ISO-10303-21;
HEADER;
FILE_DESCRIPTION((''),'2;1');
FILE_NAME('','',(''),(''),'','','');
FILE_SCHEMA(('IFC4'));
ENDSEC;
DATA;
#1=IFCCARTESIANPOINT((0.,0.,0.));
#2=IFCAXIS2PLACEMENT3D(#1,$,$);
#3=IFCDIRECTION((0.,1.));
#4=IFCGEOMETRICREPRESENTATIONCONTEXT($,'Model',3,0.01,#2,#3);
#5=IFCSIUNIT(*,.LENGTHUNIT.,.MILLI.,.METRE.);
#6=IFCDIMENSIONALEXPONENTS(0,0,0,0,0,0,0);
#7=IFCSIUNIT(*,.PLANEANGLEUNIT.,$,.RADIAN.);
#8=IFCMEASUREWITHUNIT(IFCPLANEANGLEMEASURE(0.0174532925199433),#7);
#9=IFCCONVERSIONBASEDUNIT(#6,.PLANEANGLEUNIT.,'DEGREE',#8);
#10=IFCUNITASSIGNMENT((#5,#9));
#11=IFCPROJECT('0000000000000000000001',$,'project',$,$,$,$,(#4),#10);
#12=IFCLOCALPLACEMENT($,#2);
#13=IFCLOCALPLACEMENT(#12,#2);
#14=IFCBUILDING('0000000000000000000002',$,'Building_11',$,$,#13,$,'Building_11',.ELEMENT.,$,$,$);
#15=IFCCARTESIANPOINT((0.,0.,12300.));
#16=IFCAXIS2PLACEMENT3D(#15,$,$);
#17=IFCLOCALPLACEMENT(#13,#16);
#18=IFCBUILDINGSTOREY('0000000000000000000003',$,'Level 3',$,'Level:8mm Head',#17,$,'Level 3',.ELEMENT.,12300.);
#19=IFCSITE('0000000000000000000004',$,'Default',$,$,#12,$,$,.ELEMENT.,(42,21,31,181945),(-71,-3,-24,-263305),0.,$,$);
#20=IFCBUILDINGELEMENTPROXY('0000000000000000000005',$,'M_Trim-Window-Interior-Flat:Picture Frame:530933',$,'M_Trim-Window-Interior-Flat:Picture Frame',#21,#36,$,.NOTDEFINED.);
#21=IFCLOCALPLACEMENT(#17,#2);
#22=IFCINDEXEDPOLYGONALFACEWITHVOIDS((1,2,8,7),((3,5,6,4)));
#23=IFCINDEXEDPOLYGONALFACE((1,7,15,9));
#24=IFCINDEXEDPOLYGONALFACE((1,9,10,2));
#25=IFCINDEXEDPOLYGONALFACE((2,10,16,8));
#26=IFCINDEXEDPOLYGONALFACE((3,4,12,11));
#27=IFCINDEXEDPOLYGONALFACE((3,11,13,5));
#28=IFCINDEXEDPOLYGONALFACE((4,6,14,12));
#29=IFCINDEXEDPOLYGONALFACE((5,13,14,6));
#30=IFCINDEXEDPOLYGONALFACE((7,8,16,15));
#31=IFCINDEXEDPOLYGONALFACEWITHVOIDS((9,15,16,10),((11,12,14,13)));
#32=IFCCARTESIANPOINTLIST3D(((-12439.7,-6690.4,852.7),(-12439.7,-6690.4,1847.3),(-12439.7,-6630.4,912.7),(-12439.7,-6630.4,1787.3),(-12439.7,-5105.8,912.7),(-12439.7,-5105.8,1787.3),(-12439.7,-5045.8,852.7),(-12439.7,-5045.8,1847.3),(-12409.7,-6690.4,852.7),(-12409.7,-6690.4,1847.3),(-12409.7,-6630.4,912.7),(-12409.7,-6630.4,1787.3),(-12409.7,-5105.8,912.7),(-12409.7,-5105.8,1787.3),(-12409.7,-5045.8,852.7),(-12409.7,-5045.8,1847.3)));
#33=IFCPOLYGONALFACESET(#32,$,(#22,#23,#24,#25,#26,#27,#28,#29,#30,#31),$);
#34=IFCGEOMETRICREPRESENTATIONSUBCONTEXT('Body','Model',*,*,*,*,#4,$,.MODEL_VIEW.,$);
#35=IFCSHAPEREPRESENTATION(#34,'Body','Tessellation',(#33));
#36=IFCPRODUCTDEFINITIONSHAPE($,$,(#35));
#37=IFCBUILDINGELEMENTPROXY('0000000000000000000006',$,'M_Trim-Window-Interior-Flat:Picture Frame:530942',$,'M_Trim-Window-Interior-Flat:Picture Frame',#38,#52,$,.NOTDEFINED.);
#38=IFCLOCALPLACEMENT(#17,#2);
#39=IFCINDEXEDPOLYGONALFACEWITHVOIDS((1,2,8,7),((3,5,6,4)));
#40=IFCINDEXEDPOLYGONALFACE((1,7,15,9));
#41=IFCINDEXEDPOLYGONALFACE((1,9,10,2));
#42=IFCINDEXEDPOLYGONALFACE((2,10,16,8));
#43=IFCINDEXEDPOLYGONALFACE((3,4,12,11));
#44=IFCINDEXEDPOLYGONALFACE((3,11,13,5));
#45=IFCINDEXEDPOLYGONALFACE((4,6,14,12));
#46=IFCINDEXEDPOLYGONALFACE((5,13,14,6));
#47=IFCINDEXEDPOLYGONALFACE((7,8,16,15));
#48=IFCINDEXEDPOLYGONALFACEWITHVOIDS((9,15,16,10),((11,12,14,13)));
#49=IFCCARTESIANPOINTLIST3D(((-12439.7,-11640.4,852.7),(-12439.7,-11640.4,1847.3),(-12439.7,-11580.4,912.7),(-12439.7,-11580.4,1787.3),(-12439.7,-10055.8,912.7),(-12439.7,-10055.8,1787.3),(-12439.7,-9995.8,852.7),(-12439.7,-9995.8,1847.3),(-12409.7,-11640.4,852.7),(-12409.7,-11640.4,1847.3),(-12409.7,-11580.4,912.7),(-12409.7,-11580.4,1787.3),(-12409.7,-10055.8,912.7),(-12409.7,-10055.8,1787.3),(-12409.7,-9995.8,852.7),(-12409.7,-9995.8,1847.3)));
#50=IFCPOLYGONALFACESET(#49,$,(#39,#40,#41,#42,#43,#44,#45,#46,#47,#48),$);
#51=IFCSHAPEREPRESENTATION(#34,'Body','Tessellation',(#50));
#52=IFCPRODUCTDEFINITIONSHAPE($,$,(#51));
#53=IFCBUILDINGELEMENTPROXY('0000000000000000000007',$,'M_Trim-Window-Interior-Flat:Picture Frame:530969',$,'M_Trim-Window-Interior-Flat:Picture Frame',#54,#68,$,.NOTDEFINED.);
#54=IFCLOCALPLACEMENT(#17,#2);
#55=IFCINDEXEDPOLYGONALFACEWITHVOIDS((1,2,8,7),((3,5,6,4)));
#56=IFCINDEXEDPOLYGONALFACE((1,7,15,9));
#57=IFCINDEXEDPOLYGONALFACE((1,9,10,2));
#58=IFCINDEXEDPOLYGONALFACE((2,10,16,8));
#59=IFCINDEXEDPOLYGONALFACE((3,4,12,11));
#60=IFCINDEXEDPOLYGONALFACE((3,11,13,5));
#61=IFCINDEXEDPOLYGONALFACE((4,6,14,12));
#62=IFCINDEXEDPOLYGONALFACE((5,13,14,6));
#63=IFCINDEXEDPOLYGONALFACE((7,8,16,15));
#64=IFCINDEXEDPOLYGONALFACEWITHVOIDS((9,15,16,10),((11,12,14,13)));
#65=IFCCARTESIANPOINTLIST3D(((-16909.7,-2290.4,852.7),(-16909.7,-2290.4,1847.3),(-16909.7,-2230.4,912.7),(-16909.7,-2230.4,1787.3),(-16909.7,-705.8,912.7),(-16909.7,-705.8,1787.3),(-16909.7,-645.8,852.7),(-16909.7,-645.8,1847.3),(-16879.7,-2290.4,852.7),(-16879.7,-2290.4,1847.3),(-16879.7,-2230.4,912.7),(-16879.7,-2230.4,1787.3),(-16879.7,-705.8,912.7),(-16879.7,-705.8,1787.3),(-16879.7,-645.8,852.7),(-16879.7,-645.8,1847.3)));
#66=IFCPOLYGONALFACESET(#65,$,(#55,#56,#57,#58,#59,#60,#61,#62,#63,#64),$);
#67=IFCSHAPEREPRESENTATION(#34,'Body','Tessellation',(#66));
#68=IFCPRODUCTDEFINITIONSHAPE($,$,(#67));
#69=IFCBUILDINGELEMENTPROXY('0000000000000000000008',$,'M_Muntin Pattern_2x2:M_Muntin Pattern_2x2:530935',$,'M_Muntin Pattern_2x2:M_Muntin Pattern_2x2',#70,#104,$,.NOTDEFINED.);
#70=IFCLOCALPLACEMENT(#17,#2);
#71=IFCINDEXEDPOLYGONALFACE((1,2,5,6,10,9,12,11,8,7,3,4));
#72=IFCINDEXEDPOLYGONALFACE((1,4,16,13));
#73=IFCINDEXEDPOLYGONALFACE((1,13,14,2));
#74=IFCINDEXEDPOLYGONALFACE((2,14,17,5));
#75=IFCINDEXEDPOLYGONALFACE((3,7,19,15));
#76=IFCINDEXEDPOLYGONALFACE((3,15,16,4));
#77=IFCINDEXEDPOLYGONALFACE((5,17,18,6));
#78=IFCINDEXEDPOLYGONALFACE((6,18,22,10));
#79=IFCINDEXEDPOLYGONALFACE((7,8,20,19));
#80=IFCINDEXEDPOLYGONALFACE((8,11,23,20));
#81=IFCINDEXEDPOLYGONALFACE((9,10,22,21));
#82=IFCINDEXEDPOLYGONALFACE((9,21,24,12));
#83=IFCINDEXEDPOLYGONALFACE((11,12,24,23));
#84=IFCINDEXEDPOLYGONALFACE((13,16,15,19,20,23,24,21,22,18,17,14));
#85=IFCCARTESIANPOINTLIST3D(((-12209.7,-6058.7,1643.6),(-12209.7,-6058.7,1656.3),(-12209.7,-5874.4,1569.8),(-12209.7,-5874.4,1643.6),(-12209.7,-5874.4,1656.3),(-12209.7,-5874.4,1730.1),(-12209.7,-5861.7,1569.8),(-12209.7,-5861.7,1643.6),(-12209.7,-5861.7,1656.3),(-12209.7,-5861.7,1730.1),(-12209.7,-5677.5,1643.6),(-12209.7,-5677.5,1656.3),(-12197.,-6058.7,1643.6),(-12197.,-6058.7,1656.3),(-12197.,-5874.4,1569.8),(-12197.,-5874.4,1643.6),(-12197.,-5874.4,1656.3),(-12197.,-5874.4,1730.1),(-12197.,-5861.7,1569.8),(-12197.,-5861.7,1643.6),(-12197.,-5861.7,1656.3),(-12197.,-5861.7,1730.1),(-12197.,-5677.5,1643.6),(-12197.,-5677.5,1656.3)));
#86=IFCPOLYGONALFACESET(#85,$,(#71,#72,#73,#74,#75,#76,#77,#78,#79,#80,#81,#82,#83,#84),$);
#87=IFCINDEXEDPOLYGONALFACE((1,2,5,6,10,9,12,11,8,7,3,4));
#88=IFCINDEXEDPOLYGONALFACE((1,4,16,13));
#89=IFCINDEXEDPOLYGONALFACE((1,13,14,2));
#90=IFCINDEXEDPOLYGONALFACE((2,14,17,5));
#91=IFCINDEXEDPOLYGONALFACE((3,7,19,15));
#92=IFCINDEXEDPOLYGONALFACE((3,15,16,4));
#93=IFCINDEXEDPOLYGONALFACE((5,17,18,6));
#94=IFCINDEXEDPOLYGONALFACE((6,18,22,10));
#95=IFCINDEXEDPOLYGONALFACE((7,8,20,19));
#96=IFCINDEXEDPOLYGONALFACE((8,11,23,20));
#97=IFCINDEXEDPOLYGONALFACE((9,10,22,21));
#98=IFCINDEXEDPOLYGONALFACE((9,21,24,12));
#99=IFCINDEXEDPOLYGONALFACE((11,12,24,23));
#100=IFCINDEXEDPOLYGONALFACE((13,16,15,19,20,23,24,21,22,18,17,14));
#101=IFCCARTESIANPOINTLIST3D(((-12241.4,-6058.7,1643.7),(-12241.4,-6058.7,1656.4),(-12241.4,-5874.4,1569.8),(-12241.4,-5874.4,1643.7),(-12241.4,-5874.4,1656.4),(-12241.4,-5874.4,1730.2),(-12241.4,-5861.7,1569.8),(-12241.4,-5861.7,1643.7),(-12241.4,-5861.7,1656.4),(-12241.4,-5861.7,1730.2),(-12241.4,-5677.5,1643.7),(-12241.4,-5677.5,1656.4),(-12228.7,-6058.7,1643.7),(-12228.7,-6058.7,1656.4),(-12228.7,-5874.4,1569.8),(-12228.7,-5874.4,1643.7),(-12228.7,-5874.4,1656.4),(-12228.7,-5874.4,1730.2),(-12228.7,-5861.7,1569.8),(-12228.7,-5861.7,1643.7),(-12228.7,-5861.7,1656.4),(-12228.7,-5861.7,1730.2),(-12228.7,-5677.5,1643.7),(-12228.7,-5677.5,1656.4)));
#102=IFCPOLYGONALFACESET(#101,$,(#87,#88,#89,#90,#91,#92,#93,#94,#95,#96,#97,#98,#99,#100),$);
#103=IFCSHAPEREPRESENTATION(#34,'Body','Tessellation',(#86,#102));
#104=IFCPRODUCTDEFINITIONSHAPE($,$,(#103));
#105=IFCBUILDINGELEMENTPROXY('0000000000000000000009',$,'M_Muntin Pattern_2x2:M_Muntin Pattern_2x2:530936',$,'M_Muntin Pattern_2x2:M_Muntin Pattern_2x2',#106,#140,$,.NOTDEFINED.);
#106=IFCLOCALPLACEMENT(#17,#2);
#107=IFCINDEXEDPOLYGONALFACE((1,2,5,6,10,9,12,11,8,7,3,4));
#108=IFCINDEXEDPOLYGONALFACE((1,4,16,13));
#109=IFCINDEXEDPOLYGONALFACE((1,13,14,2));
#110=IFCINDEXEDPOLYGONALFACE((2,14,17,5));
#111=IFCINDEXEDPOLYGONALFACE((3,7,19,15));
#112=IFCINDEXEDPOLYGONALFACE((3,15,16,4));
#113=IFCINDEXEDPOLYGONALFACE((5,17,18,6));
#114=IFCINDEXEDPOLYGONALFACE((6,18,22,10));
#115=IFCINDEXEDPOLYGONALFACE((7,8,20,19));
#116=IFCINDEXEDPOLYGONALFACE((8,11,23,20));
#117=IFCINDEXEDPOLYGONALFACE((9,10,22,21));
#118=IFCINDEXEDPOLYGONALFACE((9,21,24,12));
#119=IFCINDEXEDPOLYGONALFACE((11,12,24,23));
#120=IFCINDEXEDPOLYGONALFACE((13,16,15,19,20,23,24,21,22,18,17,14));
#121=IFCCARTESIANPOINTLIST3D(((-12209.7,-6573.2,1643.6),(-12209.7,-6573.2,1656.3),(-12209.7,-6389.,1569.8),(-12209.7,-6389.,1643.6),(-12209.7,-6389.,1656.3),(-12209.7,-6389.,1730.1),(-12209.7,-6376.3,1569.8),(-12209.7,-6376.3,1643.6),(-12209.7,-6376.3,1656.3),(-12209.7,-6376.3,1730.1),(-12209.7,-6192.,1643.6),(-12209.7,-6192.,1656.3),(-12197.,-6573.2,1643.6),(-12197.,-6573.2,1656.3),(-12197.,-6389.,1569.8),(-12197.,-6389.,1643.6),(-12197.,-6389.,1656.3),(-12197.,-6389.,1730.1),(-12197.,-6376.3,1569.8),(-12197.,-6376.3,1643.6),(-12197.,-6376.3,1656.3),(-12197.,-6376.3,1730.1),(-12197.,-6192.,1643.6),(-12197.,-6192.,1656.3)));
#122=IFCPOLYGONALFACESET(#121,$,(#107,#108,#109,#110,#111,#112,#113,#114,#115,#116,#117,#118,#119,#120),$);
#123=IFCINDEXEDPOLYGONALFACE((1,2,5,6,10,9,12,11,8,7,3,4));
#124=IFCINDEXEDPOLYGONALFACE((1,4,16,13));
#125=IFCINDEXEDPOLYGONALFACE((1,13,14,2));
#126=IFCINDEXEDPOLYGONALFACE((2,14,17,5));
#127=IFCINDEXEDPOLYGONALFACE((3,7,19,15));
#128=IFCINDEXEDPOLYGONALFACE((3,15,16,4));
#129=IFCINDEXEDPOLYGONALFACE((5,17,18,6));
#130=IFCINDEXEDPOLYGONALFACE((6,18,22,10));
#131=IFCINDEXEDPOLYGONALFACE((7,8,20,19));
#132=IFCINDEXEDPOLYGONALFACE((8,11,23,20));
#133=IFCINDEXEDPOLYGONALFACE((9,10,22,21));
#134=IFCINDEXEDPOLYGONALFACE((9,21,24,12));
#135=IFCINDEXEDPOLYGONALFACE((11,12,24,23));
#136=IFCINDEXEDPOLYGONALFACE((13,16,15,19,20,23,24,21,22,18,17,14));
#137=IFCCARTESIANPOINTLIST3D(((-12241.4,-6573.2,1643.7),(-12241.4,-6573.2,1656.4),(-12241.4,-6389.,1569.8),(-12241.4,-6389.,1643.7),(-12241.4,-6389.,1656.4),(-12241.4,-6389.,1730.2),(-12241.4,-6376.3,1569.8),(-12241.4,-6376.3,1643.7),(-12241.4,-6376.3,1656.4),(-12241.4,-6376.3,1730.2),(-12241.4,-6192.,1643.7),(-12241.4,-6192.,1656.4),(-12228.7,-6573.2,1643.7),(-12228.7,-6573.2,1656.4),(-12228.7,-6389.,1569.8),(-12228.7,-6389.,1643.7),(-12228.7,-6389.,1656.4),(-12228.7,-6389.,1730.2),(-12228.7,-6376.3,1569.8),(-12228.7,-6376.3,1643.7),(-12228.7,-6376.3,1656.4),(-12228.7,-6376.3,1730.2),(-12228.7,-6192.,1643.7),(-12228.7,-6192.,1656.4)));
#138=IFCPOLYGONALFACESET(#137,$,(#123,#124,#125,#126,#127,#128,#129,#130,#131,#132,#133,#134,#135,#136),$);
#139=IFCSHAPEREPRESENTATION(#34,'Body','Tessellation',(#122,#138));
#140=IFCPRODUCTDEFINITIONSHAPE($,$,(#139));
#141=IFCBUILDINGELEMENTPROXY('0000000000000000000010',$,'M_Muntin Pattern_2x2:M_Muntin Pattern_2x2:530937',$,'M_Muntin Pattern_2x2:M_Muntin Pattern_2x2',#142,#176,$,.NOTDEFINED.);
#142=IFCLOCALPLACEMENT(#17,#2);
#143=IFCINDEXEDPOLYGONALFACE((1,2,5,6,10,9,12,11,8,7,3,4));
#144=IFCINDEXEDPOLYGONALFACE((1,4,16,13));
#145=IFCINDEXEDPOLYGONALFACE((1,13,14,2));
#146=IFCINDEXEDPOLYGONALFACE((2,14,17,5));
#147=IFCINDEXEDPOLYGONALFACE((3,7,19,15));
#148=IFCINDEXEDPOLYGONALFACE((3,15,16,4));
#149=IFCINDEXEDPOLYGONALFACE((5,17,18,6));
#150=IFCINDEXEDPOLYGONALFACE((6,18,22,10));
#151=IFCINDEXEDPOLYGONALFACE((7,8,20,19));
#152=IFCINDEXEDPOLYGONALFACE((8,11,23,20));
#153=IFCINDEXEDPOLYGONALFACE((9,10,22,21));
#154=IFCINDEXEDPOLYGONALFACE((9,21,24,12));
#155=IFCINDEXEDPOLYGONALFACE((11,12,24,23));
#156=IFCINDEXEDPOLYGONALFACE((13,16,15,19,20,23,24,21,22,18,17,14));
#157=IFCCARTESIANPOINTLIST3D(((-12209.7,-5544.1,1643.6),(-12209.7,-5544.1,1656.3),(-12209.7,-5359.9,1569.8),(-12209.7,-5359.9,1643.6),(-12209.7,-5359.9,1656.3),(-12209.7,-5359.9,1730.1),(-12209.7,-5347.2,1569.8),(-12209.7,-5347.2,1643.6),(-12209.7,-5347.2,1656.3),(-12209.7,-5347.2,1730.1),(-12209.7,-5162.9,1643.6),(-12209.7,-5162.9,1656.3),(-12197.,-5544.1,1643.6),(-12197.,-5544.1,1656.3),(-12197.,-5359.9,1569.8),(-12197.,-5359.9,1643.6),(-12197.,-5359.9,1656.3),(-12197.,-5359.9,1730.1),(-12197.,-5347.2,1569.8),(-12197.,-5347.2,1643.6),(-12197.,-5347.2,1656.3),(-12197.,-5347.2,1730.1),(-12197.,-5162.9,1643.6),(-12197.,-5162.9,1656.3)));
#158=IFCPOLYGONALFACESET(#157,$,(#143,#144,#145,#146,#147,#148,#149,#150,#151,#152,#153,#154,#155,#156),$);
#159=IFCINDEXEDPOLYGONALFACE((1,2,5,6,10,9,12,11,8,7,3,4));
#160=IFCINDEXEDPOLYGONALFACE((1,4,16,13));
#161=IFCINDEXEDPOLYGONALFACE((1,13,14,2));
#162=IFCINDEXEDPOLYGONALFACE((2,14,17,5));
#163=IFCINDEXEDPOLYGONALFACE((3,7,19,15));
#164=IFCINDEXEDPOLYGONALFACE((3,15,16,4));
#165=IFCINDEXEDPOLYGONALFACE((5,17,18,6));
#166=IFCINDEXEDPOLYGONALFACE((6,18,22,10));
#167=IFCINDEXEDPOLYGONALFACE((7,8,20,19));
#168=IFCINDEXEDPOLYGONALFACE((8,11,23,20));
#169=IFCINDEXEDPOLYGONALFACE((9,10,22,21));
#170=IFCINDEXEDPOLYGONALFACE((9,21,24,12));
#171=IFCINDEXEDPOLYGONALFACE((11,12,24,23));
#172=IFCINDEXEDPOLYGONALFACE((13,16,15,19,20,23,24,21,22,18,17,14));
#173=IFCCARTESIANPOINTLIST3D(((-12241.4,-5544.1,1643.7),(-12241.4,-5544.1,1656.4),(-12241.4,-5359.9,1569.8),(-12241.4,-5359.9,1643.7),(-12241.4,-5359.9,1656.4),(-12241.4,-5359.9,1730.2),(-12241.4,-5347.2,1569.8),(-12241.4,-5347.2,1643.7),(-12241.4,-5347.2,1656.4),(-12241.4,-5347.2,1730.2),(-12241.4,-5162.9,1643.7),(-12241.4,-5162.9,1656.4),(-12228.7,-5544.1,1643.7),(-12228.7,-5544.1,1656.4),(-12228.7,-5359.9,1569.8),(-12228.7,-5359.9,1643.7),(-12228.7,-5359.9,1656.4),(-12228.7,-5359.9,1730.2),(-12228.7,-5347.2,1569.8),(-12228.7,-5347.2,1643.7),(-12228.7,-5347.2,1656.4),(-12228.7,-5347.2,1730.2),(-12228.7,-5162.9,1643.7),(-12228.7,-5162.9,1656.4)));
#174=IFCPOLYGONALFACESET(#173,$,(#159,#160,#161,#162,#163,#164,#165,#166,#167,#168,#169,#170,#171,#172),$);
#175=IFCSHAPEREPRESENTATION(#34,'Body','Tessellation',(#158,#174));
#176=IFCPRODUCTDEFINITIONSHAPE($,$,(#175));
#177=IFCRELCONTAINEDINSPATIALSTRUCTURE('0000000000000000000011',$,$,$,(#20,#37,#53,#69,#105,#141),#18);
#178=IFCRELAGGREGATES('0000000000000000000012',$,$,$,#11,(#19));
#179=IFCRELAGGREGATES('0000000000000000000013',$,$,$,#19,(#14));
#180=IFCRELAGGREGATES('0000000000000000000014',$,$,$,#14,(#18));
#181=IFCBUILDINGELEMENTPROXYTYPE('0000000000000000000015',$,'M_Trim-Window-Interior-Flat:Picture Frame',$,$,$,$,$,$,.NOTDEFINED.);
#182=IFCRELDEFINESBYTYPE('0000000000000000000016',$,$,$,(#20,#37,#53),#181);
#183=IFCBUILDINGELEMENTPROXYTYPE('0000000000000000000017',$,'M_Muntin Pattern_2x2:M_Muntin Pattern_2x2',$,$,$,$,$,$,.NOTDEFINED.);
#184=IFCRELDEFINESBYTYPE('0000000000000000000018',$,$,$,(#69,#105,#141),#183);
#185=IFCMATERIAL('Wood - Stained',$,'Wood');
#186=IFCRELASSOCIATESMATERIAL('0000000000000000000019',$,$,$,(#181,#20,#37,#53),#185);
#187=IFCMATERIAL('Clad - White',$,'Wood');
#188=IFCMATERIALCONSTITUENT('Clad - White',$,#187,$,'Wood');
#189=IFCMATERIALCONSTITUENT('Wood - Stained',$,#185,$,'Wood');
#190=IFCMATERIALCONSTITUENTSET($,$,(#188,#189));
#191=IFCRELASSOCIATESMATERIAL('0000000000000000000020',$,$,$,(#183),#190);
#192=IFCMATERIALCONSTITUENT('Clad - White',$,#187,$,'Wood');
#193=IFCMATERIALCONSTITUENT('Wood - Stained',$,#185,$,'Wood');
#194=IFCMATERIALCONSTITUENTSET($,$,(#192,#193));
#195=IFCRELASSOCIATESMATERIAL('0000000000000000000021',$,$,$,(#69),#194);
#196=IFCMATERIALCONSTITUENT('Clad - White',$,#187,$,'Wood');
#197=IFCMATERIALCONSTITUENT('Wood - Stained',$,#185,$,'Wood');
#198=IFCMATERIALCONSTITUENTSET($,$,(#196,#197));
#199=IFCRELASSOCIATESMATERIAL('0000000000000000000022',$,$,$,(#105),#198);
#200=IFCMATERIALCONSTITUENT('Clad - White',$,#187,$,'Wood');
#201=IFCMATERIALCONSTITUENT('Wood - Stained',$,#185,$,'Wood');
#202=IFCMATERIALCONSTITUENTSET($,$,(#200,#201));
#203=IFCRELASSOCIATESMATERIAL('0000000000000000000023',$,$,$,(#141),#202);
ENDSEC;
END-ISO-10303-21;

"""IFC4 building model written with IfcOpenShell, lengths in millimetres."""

from ifc_helpers import new_model, entity, si_unit, converted_unit, direction, frame, origin, place, context, subcontext, project, spatial, indexed_curve, outline, extrude, source, transform, mapped, material, constituent, constituent_set, type_object, type_shapes, element, save


model = new_model("IFC4")

# Units and contexts
model_context = context("Model", 3, precision=0.01, world=origin(), true_north=direction((0.0, 1.0)))
body_context = subcontext(model_context, "Body", "Model", "MODEL_VIEW")
ifc_project = project(units=[si_unit("LENGTHUNIT", "METRE", prefix="MILLI"), converted_unit("PLANEANGLEUNIT", "DEGREE", entity("IfcPlaneAngleMeasure", 0.0174532925199433), si_unit("PLANEANGLEUNIT", "RADIAN"), dimensions=[0, 0, 0, 0, 0, 0, 0])], contexts=[model_context])

# Site, building, storey
site_placement = place(None, origin())
site = spatial("IfcSite", under=ifc_project, at=site_placement, Name="Default", CompositionType="ELEMENT", RefLatitude=(42, 21, 31, 181945), RefLongitude=(-71, -3, -24, -263305), RefElevation=0.0)
building_placement = place(site_placement, origin())
building = spatial("IfcBuilding", under=site, at=building_placement, Name="Building_11", LongName="Building_11", CompositionType="ELEMENT")
storey_placement = place(building_placement, frame((0.0, 0.0, 12300.0)))
storey = spatial("IfcBuildingStorey", under=building, at=storey_placement, Name="Level 3", ObjectType="Level:8mm Head", LongName="Level 3", CompositionType="ELEMENT", Elevation=12300.0)

# Building element proxies
ifc_material_1 = material(Name="Clad - White", Category="Wood")
ifc_material_2 = material(Name="Wood - Stained", Category="Wood")
building_element_proxy_type_1 = type_object("IfcBuildingElementProxyType", Name="M_Trim-Window-Interior-Flat:Picture Frame", PredefinedType="NOTDEFINED", material=ifc_material_2)
shared_shape_1 = source(origin(), body_context, "Body", "SweptSolid", [
    extrude(outline(indexed_curve([(-822.3, -497.3), (822.3, -497.3), (822.3, 497.3), (-822.3, 497.3), (-822.3, -497.3)], self_intersect=False), holes=[indexed_curve([(-762.3, -437.3), (-762.3, 437.3), (762.3, 437.3), (762.3, -437.3), (-762.3, -437.3)], self_intersect=False)]), frame((0.0, -450.0, 0.0), z_axis=(0.0, 0.0, 1.0), x_axis=(-1.0, 0.0, 0.0)), (0.0, 0.0, 1.0), 30.0),
])
type_shapes(building_element_proxy_type_1, [shared_shape_1])
for number, where, z_axis, x_axis, name in (
    (1, (-12409.7, -5868.1, 1800.0), (-1.0, 0.0, 0.0), (0.0, -1.0, 0.0), "M_Trim-Window-Interior-Flat:Picture Frame:530933"),
    (2, (-12409.7, -10818.1, 1800.0), (-1.0, 0.0, 0.0), (0.0, -1.0, 0.0), "M_Trim-Window-Interior-Flat:Picture Frame:530942"),
    (3, (-16909.7, -1468.1, 1800.0), (1.0, 0.0, 0.0), (0.0, 1.0, 0.0), "M_Trim-Window-Interior-Flat:Picture Frame:530969"),
):
    element("IfcBuildingElementProxy", number, at=place(storey_placement, frame(where, z_axis=z_axis, x_axis=x_axis)), inside=storey, type_object=building_element_proxy_type_1, material=ifc_material_2, Name=name, ObjectType="M_Trim-Window-Interior-Flat:Picture Frame", PredefinedType="NOTDEFINED", context=body_context, shape_type="MappedRepresentation", body=[
        mapped(shared_shape_1, transform((0.0, 0.0, 0.0), scale=1.0)),
    ])
ifc_constituent_1 = constituent(ifc_material_1, Name="Clad - White", Category="Wood")
ifc_constituent_2 = constituent(ifc_material_2, Name="Wood - Stained", Category="Wood")
ifc_constituent_set_1 = constituent_set(constituents=[ifc_constituent_1, ifc_constituent_2])
ifc_constituent_3 = constituent(ifc_material_1, Name="Clad - White", Category="Wood")
ifc_constituent_4 = constituent(ifc_material_2, Name="Wood - Stained", Category="Wood")
ifc_constituent_set_2 = constituent_set(constituents=[ifc_constituent_3, ifc_constituent_4])
building_element_proxy_type_2 = type_object("IfcBuildingElementProxyType", Name="M_Muntin Pattern_2x2:M_Muntin Pattern_2x2", PredefinedType="NOTDEFINED", material=ifc_constituent_set_2)
shared_shape_2 = source(origin(), body_context, "Body", "SweptSolid", [
    extrude(outline(indexed_curve([(6.4, -6.4), (80.1, -6.4), (80.1, 6.3), (6.4, 6.3), (6.4, 190.6), (-6.3, 190.6), (-6.3, 6.3), (-80.2, 6.3), (-80.2, -6.4), (-6.3, -6.4), (-6.3, -190.6), (6.4, -190.6), (6.4, -6.4)], self_intersect=False)), frame((0.0, 9.5, 80.1), z_axis=(0.0, 1.0, 0.0), x_axis=(0.0, 0.0, 1.0)), (0.0, 0.0, 1.0), 12.7),
    extrude(outline(indexed_curve([(6.4, -6.4), (80.2, -6.4), (80.2, 6.3), (6.4, 6.3), (6.4, 190.6), (-6.3, 190.6), (-6.3, 6.3), (-80.2, 6.3), (-80.2, -6.4), (-6.3, -6.4), (-6.3, -190.6), (6.4, -190.6), (6.4, -6.4)], self_intersect=False)), frame((0.0, -22.2, 80.2), z_axis=(0.0, 1.0, 0.0), x_axis=(0.0, 0.0, 1.0)), (0.0, 0.0, 1.0), 12.7),
])
type_shapes(building_element_proxy_type_2, [shared_shape_2])
proxy_1_placement = place(storey_placement, frame((-12219.2, -5868.1, 1569.8), z_axis=(0.0, 0.0, 1.0), x_axis=(0.0, -1.0, 0.0)))
element("IfcBuildingElementProxy", 4, at=proxy_1_placement, inside=storey, type_object=building_element_proxy_type_2, material=ifc_constituent_set_1, Name="M_Muntin Pattern_2x2:M_Muntin Pattern_2x2:530935", ObjectType="M_Muntin Pattern_2x2:M_Muntin Pattern_2x2", PredefinedType="NOTDEFINED", context=body_context, shape_type="MappedRepresentation", body=[
    mapped(shared_shape_2, transform((0.0, 0.0, 0.0), scale=1.0)),
])
ifc_constituent_5 = constituent(ifc_material_1, Name="Clad - White", Category="Wood")
ifc_constituent_6 = constituent(ifc_material_2, Name="Wood - Stained", Category="Wood")
ifc_constituent_set_3 = constituent_set(constituents=[ifc_constituent_5, ifc_constituent_6])
proxy_2_placement = place(storey_placement, frame((-12219.2, -6382.6, 1569.8), z_axis=(0.0, 0.0, 1.0), x_axis=(0.0, -1.0, 0.0)))
element("IfcBuildingElementProxy", 5, at=proxy_2_placement, inside=storey, type_object=building_element_proxy_type_2, material=ifc_constituent_set_3, Name="M_Muntin Pattern_2x2:M_Muntin Pattern_2x2:530936", ObjectType="M_Muntin Pattern_2x2:M_Muntin Pattern_2x2", PredefinedType="NOTDEFINED", context=body_context, shape_type="MappedRepresentation", body=[
    mapped(shared_shape_2, transform((0.0, 0.0, 0.0), scale=1.0)),
])
ifc_constituent_7 = constituent(ifc_material_1, Name="Clad - White", Category="Wood")
ifc_constituent_8 = constituent(ifc_material_2, Name="Wood - Stained", Category="Wood")
ifc_constituent_set_4 = constituent_set(constituents=[ifc_constituent_7, ifc_constituent_8])
proxy_3_placement = place(storey_placement, frame((-12219.2, -5353.5, 1569.8), z_axis=(0.0, 0.0, 1.0), x_axis=(0.0, -1.0, 0.0)))
element("IfcBuildingElementProxy", 6, at=proxy_3_placement, inside=storey, type_object=building_element_proxy_type_2, material=ifc_constituent_set_4, Name="M_Muntin Pattern_2x2:M_Muntin Pattern_2x2:530937", ObjectType="M_Muntin Pattern_2x2:M_Muntin Pattern_2x2", PredefinedType="NOTDEFINED", context=body_context, shape_type="MappedRepresentation", body=[
    mapped(shared_shape_2, transform((0.0, 0.0, 0.0), scale=1.0)),
])

save(model, "model.ifc")
